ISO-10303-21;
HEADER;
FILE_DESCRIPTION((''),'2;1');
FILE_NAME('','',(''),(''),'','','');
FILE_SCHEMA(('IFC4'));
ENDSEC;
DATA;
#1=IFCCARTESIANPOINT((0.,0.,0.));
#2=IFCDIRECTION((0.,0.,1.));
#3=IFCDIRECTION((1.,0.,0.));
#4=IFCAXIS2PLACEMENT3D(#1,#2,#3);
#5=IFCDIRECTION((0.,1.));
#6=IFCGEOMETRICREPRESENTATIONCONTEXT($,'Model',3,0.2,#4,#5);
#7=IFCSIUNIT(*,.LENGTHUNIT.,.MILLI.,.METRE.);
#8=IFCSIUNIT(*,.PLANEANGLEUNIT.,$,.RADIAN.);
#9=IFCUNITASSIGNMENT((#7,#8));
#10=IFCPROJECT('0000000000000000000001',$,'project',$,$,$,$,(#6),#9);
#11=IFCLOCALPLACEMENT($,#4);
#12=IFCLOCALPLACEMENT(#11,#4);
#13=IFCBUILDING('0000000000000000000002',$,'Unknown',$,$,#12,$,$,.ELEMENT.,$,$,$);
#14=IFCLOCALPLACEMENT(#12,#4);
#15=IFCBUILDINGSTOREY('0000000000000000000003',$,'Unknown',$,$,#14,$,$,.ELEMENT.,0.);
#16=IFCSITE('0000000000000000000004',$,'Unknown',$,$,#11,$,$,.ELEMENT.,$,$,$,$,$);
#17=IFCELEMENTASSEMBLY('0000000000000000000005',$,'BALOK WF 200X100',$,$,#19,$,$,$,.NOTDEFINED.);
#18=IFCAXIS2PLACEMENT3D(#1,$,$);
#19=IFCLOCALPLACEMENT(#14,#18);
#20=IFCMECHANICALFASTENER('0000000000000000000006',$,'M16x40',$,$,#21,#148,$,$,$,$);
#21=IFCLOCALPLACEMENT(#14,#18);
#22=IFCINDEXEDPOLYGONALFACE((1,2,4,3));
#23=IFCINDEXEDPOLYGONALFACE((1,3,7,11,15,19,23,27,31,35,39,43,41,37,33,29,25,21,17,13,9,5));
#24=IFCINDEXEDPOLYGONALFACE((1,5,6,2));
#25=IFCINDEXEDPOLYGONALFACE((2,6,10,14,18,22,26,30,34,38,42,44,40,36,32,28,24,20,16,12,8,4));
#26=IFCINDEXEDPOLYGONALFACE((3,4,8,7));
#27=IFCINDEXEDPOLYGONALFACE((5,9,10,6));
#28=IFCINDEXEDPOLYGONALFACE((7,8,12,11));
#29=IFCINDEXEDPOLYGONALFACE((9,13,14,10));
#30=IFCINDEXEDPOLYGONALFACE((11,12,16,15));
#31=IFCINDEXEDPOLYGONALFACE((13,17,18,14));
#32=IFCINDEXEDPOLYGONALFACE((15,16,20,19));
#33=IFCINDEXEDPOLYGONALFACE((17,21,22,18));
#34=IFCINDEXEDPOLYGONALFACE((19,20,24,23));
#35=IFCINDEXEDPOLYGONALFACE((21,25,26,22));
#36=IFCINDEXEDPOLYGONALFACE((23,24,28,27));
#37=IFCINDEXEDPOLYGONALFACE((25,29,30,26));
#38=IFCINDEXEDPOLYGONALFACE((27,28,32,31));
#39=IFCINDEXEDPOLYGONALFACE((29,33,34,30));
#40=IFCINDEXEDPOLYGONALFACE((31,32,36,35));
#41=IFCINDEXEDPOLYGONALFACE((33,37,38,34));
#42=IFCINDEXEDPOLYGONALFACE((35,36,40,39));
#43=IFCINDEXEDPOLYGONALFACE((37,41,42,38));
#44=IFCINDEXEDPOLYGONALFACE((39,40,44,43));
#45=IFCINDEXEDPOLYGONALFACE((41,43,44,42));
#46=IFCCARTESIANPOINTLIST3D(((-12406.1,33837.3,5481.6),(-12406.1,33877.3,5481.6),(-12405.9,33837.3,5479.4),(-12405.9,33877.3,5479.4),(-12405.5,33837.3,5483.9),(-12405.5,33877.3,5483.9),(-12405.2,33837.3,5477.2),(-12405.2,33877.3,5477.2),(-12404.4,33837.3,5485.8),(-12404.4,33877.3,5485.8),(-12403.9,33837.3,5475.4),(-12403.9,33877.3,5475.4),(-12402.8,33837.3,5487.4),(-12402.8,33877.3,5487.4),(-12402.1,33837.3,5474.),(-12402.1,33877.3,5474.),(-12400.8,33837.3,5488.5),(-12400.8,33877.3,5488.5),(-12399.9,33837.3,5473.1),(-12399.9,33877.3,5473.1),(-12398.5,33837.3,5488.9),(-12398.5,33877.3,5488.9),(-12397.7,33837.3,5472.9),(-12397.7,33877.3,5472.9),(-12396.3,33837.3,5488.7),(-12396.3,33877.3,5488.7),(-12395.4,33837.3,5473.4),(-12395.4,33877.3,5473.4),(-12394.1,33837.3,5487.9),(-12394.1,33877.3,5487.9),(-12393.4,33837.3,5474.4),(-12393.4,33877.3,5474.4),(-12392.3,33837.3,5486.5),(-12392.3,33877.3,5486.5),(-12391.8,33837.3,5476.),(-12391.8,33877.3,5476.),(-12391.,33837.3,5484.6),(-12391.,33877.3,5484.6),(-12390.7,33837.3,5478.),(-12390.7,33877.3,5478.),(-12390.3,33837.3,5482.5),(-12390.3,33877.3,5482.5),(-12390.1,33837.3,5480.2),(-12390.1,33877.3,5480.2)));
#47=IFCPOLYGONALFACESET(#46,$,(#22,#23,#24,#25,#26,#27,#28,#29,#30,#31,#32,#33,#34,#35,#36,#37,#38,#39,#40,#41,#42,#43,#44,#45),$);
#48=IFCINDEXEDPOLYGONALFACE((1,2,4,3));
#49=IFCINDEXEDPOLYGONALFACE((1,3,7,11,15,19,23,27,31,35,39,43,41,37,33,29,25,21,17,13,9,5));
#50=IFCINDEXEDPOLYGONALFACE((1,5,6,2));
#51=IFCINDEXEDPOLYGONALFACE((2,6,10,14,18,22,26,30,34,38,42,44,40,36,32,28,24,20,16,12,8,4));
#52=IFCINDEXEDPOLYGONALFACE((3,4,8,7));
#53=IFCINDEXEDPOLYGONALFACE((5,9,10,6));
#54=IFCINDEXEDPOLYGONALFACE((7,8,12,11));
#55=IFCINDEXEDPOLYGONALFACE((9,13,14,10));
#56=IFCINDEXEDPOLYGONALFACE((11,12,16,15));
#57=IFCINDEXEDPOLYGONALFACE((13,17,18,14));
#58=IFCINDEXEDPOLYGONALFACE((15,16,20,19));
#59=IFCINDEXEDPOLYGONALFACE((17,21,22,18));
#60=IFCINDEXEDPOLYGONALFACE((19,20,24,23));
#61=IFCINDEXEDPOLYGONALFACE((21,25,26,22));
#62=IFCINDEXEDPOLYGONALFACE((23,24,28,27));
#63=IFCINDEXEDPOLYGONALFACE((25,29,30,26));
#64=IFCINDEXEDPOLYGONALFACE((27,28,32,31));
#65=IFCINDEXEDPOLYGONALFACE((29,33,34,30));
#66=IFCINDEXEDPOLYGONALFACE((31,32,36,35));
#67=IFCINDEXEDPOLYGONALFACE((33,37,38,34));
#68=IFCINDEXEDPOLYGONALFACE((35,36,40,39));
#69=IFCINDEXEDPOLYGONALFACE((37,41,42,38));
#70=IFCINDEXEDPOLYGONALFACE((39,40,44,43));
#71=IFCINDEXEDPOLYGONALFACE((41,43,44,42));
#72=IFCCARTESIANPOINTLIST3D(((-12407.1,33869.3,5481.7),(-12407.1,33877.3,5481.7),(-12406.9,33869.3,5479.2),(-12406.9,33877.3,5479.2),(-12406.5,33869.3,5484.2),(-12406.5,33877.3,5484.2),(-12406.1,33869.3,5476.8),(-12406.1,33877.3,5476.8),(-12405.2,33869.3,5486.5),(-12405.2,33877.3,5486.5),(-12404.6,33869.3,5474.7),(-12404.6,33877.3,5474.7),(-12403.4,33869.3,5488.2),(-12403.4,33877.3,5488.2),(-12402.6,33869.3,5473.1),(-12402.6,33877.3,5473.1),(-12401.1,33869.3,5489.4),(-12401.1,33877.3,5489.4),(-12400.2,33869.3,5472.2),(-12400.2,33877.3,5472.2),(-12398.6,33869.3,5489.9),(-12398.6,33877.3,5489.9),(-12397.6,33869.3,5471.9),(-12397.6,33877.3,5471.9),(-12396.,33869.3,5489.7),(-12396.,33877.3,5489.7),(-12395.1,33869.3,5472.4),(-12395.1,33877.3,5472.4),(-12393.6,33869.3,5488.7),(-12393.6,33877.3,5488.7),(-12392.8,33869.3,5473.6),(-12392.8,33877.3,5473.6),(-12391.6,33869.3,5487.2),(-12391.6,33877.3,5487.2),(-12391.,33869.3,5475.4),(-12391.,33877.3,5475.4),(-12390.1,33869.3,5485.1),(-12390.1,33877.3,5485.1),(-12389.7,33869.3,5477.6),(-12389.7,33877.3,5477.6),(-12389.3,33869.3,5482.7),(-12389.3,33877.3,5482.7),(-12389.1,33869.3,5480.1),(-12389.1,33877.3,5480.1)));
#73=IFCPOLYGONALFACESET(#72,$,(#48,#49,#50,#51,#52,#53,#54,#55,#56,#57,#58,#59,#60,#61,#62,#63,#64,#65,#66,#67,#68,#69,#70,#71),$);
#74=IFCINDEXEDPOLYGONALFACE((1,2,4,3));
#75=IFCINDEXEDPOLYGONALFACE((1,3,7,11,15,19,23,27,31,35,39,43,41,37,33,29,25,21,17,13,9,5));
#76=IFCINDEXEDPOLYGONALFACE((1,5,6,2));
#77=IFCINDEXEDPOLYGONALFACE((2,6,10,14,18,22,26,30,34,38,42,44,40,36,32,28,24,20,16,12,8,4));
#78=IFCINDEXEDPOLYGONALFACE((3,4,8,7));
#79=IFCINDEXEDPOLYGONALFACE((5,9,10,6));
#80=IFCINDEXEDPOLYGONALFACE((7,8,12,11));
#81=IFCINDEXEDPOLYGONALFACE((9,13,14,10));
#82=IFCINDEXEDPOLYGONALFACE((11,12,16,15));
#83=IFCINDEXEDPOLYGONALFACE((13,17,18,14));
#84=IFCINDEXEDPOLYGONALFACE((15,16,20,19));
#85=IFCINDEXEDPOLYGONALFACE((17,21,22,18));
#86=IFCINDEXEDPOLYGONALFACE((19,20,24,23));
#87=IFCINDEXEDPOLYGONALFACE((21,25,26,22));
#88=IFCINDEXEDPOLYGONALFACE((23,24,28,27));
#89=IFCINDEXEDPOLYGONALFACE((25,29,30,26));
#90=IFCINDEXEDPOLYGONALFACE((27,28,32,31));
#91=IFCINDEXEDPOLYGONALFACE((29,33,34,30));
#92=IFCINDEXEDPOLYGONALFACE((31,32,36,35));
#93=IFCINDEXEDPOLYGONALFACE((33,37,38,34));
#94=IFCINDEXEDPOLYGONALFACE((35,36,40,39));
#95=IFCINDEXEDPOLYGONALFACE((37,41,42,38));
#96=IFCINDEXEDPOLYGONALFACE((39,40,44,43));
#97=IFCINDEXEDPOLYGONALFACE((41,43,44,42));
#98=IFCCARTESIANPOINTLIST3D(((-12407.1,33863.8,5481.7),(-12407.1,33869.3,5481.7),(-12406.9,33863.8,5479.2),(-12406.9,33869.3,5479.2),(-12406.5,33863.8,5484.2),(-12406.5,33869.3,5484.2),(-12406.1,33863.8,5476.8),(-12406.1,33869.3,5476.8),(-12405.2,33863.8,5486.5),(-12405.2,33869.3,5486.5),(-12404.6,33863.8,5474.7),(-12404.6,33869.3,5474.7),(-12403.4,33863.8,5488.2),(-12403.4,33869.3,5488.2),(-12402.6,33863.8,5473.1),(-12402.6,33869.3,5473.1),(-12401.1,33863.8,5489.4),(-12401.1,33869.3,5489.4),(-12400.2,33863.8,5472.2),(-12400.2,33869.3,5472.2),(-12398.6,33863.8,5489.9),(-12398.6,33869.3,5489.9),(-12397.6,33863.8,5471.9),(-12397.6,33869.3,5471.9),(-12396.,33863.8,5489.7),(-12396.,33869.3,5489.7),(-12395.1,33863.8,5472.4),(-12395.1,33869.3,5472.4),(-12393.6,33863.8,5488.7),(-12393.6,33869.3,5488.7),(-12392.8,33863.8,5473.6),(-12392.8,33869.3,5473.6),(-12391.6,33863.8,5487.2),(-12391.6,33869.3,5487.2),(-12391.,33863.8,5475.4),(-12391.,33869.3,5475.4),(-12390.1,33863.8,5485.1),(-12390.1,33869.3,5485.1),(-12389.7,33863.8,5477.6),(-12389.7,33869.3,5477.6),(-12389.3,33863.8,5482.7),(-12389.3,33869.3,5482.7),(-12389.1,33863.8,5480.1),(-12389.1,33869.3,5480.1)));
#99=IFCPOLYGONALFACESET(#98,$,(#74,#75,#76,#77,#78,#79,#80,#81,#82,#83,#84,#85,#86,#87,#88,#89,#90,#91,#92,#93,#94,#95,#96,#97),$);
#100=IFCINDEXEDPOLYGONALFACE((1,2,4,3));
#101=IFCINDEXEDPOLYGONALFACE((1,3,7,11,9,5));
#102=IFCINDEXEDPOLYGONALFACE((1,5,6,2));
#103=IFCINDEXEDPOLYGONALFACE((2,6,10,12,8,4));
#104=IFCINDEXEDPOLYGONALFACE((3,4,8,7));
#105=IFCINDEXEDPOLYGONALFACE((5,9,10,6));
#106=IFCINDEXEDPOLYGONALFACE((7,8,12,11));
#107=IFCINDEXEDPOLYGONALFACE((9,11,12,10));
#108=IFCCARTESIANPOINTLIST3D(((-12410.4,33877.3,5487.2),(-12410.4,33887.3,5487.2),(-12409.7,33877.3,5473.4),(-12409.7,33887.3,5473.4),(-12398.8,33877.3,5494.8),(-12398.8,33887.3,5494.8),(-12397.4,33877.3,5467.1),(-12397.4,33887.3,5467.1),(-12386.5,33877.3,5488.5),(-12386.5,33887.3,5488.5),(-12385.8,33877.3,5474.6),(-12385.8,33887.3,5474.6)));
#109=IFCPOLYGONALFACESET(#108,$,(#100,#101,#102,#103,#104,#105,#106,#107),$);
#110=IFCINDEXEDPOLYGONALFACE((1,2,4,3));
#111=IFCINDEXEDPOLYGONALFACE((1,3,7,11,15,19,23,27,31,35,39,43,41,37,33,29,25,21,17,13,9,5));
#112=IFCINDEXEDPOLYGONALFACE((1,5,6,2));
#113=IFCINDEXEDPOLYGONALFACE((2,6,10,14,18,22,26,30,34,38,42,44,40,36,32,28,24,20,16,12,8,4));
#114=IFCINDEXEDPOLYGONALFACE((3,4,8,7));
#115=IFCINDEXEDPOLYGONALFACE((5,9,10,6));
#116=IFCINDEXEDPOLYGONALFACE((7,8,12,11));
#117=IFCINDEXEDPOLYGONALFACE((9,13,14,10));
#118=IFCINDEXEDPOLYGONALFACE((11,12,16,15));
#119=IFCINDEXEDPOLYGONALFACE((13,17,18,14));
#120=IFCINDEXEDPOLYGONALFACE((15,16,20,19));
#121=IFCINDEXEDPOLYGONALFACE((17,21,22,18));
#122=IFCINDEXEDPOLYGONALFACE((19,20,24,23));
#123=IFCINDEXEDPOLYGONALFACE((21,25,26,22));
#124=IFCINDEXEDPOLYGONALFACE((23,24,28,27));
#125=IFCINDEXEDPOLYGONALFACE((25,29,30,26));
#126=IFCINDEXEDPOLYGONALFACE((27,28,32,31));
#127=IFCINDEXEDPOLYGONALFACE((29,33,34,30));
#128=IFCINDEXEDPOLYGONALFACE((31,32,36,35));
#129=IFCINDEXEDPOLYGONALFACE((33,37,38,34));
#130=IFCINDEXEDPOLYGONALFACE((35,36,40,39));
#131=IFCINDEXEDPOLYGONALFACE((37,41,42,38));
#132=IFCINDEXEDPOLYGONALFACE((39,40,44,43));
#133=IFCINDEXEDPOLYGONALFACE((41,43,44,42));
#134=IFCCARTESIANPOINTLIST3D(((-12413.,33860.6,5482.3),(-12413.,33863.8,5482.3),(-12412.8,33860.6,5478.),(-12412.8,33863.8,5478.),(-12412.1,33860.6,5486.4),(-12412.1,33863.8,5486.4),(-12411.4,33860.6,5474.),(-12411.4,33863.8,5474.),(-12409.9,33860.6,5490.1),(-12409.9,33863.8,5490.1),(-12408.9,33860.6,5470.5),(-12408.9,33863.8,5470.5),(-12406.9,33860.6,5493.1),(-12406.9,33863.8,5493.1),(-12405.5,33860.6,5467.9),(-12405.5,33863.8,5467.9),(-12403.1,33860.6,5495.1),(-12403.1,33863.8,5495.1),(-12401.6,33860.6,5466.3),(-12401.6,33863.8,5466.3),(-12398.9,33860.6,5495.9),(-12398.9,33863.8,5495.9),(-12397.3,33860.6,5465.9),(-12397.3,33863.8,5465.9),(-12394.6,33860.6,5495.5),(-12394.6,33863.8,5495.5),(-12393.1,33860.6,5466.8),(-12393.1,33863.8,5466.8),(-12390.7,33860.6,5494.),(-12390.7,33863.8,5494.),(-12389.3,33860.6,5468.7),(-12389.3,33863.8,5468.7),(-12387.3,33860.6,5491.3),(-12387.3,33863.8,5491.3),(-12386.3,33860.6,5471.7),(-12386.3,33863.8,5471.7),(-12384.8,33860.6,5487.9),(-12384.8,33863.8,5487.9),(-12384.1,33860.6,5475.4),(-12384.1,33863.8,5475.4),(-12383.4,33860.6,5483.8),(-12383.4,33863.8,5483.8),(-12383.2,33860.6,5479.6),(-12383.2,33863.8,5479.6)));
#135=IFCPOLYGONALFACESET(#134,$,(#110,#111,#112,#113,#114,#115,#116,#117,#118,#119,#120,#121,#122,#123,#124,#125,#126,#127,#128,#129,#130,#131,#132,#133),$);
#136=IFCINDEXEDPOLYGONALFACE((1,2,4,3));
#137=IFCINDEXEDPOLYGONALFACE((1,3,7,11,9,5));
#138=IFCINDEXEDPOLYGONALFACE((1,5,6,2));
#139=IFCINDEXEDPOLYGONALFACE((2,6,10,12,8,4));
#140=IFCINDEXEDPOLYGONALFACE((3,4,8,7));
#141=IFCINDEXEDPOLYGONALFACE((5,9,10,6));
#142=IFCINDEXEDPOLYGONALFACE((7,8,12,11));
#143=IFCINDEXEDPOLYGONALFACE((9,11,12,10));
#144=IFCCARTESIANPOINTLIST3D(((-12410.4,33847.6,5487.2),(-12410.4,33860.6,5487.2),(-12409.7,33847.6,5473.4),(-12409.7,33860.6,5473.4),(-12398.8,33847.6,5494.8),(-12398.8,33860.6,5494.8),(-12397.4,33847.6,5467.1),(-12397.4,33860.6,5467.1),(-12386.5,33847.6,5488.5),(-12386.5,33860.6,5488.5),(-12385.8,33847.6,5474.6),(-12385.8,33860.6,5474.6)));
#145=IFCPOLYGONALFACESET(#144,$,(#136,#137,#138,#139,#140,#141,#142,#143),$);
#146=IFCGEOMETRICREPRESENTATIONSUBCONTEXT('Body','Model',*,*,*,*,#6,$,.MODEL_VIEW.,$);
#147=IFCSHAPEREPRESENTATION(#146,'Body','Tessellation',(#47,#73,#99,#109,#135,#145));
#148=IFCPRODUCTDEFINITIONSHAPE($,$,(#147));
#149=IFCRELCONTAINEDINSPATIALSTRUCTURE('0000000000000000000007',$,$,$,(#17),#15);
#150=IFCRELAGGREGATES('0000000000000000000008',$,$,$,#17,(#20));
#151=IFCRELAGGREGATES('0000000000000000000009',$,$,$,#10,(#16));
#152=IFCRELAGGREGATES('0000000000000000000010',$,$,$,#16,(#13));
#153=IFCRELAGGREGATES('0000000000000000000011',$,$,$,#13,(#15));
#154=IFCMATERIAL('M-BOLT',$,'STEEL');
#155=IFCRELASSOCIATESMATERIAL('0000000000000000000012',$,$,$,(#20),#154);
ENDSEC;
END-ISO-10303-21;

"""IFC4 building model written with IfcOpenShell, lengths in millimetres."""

from ifc_helpers import new_model, si_unit, direction, frame, origin_with_axes, place, context, subcontext, project, spatial, line, arc, indexed_curve, outline, extrude, source, transform, mapped, material, element, aggregate, save


model = new_model("IFC4")

# Units and contexts
model_context = context("Model", 3, precision=0.2, world=origin_with_axes(), true_north=direction((0.0, 1.0)))
body_context = subcontext(model_context, "Body", "Model", "MODEL_VIEW")
ifc_project = project(units=[si_unit("LENGTHUNIT", "METRE", prefix="MILLI"), si_unit("PLANEANGLEUNIT", "RADIAN")], contexts=[model_context])

# Site, building, storey
site_placement = place(None, origin_with_axes())
site = spatial("IfcSite", under=ifc_project, at=site_placement, Name="Unknown", CompositionType="ELEMENT")
building_placement = place(site_placement, origin_with_axes())
building = spatial("IfcBuilding", under=site, at=building_placement, Name="Unknown", CompositionType="ELEMENT")
storey_placement = place(building_placement, origin_with_axes())
storey = spatial("IfcBuildingStorey", under=building, at=storey_placement, Name="Unknown", CompositionType="ELEMENT", Elevation=0.0)

# Element assembly, mechanical fastener
assembly_1_placement = place(storey_placement, frame((-7044.1, 33866.5, 5721.5), z_axis=(0.0, 1.0, 0.0), x_axis=(-0.99863, 0.0, -0.052336)))
assembly_1 = element("IfcElementAssembly", 1, at=assembly_1_placement, inside=storey, Name="BALOK WF 200X100", PredefinedType="NOTDEFINED")
ifc_material_1 = material(Name="M-BOLT", Category="STEEL")
shared_shape_1 = source(origin_with_axes(), body_context, "Body", "SweptSolid", [
    extrude(outline(indexed_curve([(8.0, 0.0), (0.0, 8.0), (-8.0, 0.0), (0.0, -8.0)], segments=[arc(1, 2, 3), arc(3, 4, 1)])), frame((0.0, 0.0, 0.0), z_axis=(0.0, 0.0, -1.0), x_axis=(0.0, 1.0, 0.0)), (0.0, 0.0, 1.0), 40.0),
    extrude(outline(indexed_curve([(9.0, 0.0), (0.0, 9.0), (-9.0, 0.0), (0.0, -9.0)], segments=[arc(1, 2, 3), arc(3, 4, 1)])), frame((0.0, 0.0, 0.0), z_axis=(0.0, 0.0, -1.0), x_axis=(0.0, 1.0, 0.0)), (0.0, 0.0, 1.0), 8.0),
    extrude(outline(indexed_curve([(9.0, 0.0), (0.0, 9.0), (-9.0, 0.0), (0.0, -9.0)], segments=[arc(1, 2, 3), arc(3, 4, 1)])), frame((0.0, 0.0, -8.0), z_axis=(0.0, 0.0, -1.0), x_axis=(0.0, 1.0, 0.0)), (0.0, 0.0, 1.0), 5.5),
    extrude(outline(indexed_curve([(13.9, 0.0), (6.9, 12.0), (-6.9, 12.0), (-13.9, 0.0), (-6.9, -12.0), (6.9, -12.0)], segments=[line(1, 2, 3, 4, 5, 6, 1)])), frame((0.0, 0.0, 10.0), z_axis=(0.0, 0.0, -1.0), x_axis=(0.0, 1.0, 0.0)), (0.0, 0.0, 1.0), 10.0),
    extrude(outline(indexed_curve([(15.0, 0.0), (0.0, 15.0), (-15.0, 0.0), (0.0, -15.0)], segments=[arc(1, 2, 3), arc(3, 4, 1)])), frame((0.0, 0.0, -13.5), z_axis=(0.0, 0.0, -1.0), x_axis=(0.0, 1.0, 0.0)), (0.0, 0.0, 1.0), 3.2),
    extrude(outline(indexed_curve([(13.9, 0.0), (6.9, 12.0), (-6.9, 12.0), (-13.9, 0.0), (-6.9, -12.0), (6.9, -12.0)], segments=[line(1, 2, 3, 4, 5, 6, 1)])), frame((0.0, 0.0, -16.7), z_axis=(0.0, 0.0, -1.0), x_axis=(0.0, 1.0, 0.0)), (0.0, 0.0, 1.0), 13.0),
])
mechanical_fastener_1_placement = place(assembly_1_placement, frame((5359.2, 40.0, 10.7), z_axis=(-0.000004, 0.0, 1.0), x_axis=(-1.0, 0.0, -0.000004)))
mechanical_fastener_1 = element("IfcMechanicalFastener", 2, at=mechanical_fastener_1_placement, material=ifc_material_1, Name="M16x40", context=body_context, shape_type="MappedRepresentation", body=[
    mapped(shared_shape_1, transform((0.0, 0.0, 0.0))),
])
aggregate(assembly_1, [mechanical_fastener_1])

save(model, "model.ifc")
